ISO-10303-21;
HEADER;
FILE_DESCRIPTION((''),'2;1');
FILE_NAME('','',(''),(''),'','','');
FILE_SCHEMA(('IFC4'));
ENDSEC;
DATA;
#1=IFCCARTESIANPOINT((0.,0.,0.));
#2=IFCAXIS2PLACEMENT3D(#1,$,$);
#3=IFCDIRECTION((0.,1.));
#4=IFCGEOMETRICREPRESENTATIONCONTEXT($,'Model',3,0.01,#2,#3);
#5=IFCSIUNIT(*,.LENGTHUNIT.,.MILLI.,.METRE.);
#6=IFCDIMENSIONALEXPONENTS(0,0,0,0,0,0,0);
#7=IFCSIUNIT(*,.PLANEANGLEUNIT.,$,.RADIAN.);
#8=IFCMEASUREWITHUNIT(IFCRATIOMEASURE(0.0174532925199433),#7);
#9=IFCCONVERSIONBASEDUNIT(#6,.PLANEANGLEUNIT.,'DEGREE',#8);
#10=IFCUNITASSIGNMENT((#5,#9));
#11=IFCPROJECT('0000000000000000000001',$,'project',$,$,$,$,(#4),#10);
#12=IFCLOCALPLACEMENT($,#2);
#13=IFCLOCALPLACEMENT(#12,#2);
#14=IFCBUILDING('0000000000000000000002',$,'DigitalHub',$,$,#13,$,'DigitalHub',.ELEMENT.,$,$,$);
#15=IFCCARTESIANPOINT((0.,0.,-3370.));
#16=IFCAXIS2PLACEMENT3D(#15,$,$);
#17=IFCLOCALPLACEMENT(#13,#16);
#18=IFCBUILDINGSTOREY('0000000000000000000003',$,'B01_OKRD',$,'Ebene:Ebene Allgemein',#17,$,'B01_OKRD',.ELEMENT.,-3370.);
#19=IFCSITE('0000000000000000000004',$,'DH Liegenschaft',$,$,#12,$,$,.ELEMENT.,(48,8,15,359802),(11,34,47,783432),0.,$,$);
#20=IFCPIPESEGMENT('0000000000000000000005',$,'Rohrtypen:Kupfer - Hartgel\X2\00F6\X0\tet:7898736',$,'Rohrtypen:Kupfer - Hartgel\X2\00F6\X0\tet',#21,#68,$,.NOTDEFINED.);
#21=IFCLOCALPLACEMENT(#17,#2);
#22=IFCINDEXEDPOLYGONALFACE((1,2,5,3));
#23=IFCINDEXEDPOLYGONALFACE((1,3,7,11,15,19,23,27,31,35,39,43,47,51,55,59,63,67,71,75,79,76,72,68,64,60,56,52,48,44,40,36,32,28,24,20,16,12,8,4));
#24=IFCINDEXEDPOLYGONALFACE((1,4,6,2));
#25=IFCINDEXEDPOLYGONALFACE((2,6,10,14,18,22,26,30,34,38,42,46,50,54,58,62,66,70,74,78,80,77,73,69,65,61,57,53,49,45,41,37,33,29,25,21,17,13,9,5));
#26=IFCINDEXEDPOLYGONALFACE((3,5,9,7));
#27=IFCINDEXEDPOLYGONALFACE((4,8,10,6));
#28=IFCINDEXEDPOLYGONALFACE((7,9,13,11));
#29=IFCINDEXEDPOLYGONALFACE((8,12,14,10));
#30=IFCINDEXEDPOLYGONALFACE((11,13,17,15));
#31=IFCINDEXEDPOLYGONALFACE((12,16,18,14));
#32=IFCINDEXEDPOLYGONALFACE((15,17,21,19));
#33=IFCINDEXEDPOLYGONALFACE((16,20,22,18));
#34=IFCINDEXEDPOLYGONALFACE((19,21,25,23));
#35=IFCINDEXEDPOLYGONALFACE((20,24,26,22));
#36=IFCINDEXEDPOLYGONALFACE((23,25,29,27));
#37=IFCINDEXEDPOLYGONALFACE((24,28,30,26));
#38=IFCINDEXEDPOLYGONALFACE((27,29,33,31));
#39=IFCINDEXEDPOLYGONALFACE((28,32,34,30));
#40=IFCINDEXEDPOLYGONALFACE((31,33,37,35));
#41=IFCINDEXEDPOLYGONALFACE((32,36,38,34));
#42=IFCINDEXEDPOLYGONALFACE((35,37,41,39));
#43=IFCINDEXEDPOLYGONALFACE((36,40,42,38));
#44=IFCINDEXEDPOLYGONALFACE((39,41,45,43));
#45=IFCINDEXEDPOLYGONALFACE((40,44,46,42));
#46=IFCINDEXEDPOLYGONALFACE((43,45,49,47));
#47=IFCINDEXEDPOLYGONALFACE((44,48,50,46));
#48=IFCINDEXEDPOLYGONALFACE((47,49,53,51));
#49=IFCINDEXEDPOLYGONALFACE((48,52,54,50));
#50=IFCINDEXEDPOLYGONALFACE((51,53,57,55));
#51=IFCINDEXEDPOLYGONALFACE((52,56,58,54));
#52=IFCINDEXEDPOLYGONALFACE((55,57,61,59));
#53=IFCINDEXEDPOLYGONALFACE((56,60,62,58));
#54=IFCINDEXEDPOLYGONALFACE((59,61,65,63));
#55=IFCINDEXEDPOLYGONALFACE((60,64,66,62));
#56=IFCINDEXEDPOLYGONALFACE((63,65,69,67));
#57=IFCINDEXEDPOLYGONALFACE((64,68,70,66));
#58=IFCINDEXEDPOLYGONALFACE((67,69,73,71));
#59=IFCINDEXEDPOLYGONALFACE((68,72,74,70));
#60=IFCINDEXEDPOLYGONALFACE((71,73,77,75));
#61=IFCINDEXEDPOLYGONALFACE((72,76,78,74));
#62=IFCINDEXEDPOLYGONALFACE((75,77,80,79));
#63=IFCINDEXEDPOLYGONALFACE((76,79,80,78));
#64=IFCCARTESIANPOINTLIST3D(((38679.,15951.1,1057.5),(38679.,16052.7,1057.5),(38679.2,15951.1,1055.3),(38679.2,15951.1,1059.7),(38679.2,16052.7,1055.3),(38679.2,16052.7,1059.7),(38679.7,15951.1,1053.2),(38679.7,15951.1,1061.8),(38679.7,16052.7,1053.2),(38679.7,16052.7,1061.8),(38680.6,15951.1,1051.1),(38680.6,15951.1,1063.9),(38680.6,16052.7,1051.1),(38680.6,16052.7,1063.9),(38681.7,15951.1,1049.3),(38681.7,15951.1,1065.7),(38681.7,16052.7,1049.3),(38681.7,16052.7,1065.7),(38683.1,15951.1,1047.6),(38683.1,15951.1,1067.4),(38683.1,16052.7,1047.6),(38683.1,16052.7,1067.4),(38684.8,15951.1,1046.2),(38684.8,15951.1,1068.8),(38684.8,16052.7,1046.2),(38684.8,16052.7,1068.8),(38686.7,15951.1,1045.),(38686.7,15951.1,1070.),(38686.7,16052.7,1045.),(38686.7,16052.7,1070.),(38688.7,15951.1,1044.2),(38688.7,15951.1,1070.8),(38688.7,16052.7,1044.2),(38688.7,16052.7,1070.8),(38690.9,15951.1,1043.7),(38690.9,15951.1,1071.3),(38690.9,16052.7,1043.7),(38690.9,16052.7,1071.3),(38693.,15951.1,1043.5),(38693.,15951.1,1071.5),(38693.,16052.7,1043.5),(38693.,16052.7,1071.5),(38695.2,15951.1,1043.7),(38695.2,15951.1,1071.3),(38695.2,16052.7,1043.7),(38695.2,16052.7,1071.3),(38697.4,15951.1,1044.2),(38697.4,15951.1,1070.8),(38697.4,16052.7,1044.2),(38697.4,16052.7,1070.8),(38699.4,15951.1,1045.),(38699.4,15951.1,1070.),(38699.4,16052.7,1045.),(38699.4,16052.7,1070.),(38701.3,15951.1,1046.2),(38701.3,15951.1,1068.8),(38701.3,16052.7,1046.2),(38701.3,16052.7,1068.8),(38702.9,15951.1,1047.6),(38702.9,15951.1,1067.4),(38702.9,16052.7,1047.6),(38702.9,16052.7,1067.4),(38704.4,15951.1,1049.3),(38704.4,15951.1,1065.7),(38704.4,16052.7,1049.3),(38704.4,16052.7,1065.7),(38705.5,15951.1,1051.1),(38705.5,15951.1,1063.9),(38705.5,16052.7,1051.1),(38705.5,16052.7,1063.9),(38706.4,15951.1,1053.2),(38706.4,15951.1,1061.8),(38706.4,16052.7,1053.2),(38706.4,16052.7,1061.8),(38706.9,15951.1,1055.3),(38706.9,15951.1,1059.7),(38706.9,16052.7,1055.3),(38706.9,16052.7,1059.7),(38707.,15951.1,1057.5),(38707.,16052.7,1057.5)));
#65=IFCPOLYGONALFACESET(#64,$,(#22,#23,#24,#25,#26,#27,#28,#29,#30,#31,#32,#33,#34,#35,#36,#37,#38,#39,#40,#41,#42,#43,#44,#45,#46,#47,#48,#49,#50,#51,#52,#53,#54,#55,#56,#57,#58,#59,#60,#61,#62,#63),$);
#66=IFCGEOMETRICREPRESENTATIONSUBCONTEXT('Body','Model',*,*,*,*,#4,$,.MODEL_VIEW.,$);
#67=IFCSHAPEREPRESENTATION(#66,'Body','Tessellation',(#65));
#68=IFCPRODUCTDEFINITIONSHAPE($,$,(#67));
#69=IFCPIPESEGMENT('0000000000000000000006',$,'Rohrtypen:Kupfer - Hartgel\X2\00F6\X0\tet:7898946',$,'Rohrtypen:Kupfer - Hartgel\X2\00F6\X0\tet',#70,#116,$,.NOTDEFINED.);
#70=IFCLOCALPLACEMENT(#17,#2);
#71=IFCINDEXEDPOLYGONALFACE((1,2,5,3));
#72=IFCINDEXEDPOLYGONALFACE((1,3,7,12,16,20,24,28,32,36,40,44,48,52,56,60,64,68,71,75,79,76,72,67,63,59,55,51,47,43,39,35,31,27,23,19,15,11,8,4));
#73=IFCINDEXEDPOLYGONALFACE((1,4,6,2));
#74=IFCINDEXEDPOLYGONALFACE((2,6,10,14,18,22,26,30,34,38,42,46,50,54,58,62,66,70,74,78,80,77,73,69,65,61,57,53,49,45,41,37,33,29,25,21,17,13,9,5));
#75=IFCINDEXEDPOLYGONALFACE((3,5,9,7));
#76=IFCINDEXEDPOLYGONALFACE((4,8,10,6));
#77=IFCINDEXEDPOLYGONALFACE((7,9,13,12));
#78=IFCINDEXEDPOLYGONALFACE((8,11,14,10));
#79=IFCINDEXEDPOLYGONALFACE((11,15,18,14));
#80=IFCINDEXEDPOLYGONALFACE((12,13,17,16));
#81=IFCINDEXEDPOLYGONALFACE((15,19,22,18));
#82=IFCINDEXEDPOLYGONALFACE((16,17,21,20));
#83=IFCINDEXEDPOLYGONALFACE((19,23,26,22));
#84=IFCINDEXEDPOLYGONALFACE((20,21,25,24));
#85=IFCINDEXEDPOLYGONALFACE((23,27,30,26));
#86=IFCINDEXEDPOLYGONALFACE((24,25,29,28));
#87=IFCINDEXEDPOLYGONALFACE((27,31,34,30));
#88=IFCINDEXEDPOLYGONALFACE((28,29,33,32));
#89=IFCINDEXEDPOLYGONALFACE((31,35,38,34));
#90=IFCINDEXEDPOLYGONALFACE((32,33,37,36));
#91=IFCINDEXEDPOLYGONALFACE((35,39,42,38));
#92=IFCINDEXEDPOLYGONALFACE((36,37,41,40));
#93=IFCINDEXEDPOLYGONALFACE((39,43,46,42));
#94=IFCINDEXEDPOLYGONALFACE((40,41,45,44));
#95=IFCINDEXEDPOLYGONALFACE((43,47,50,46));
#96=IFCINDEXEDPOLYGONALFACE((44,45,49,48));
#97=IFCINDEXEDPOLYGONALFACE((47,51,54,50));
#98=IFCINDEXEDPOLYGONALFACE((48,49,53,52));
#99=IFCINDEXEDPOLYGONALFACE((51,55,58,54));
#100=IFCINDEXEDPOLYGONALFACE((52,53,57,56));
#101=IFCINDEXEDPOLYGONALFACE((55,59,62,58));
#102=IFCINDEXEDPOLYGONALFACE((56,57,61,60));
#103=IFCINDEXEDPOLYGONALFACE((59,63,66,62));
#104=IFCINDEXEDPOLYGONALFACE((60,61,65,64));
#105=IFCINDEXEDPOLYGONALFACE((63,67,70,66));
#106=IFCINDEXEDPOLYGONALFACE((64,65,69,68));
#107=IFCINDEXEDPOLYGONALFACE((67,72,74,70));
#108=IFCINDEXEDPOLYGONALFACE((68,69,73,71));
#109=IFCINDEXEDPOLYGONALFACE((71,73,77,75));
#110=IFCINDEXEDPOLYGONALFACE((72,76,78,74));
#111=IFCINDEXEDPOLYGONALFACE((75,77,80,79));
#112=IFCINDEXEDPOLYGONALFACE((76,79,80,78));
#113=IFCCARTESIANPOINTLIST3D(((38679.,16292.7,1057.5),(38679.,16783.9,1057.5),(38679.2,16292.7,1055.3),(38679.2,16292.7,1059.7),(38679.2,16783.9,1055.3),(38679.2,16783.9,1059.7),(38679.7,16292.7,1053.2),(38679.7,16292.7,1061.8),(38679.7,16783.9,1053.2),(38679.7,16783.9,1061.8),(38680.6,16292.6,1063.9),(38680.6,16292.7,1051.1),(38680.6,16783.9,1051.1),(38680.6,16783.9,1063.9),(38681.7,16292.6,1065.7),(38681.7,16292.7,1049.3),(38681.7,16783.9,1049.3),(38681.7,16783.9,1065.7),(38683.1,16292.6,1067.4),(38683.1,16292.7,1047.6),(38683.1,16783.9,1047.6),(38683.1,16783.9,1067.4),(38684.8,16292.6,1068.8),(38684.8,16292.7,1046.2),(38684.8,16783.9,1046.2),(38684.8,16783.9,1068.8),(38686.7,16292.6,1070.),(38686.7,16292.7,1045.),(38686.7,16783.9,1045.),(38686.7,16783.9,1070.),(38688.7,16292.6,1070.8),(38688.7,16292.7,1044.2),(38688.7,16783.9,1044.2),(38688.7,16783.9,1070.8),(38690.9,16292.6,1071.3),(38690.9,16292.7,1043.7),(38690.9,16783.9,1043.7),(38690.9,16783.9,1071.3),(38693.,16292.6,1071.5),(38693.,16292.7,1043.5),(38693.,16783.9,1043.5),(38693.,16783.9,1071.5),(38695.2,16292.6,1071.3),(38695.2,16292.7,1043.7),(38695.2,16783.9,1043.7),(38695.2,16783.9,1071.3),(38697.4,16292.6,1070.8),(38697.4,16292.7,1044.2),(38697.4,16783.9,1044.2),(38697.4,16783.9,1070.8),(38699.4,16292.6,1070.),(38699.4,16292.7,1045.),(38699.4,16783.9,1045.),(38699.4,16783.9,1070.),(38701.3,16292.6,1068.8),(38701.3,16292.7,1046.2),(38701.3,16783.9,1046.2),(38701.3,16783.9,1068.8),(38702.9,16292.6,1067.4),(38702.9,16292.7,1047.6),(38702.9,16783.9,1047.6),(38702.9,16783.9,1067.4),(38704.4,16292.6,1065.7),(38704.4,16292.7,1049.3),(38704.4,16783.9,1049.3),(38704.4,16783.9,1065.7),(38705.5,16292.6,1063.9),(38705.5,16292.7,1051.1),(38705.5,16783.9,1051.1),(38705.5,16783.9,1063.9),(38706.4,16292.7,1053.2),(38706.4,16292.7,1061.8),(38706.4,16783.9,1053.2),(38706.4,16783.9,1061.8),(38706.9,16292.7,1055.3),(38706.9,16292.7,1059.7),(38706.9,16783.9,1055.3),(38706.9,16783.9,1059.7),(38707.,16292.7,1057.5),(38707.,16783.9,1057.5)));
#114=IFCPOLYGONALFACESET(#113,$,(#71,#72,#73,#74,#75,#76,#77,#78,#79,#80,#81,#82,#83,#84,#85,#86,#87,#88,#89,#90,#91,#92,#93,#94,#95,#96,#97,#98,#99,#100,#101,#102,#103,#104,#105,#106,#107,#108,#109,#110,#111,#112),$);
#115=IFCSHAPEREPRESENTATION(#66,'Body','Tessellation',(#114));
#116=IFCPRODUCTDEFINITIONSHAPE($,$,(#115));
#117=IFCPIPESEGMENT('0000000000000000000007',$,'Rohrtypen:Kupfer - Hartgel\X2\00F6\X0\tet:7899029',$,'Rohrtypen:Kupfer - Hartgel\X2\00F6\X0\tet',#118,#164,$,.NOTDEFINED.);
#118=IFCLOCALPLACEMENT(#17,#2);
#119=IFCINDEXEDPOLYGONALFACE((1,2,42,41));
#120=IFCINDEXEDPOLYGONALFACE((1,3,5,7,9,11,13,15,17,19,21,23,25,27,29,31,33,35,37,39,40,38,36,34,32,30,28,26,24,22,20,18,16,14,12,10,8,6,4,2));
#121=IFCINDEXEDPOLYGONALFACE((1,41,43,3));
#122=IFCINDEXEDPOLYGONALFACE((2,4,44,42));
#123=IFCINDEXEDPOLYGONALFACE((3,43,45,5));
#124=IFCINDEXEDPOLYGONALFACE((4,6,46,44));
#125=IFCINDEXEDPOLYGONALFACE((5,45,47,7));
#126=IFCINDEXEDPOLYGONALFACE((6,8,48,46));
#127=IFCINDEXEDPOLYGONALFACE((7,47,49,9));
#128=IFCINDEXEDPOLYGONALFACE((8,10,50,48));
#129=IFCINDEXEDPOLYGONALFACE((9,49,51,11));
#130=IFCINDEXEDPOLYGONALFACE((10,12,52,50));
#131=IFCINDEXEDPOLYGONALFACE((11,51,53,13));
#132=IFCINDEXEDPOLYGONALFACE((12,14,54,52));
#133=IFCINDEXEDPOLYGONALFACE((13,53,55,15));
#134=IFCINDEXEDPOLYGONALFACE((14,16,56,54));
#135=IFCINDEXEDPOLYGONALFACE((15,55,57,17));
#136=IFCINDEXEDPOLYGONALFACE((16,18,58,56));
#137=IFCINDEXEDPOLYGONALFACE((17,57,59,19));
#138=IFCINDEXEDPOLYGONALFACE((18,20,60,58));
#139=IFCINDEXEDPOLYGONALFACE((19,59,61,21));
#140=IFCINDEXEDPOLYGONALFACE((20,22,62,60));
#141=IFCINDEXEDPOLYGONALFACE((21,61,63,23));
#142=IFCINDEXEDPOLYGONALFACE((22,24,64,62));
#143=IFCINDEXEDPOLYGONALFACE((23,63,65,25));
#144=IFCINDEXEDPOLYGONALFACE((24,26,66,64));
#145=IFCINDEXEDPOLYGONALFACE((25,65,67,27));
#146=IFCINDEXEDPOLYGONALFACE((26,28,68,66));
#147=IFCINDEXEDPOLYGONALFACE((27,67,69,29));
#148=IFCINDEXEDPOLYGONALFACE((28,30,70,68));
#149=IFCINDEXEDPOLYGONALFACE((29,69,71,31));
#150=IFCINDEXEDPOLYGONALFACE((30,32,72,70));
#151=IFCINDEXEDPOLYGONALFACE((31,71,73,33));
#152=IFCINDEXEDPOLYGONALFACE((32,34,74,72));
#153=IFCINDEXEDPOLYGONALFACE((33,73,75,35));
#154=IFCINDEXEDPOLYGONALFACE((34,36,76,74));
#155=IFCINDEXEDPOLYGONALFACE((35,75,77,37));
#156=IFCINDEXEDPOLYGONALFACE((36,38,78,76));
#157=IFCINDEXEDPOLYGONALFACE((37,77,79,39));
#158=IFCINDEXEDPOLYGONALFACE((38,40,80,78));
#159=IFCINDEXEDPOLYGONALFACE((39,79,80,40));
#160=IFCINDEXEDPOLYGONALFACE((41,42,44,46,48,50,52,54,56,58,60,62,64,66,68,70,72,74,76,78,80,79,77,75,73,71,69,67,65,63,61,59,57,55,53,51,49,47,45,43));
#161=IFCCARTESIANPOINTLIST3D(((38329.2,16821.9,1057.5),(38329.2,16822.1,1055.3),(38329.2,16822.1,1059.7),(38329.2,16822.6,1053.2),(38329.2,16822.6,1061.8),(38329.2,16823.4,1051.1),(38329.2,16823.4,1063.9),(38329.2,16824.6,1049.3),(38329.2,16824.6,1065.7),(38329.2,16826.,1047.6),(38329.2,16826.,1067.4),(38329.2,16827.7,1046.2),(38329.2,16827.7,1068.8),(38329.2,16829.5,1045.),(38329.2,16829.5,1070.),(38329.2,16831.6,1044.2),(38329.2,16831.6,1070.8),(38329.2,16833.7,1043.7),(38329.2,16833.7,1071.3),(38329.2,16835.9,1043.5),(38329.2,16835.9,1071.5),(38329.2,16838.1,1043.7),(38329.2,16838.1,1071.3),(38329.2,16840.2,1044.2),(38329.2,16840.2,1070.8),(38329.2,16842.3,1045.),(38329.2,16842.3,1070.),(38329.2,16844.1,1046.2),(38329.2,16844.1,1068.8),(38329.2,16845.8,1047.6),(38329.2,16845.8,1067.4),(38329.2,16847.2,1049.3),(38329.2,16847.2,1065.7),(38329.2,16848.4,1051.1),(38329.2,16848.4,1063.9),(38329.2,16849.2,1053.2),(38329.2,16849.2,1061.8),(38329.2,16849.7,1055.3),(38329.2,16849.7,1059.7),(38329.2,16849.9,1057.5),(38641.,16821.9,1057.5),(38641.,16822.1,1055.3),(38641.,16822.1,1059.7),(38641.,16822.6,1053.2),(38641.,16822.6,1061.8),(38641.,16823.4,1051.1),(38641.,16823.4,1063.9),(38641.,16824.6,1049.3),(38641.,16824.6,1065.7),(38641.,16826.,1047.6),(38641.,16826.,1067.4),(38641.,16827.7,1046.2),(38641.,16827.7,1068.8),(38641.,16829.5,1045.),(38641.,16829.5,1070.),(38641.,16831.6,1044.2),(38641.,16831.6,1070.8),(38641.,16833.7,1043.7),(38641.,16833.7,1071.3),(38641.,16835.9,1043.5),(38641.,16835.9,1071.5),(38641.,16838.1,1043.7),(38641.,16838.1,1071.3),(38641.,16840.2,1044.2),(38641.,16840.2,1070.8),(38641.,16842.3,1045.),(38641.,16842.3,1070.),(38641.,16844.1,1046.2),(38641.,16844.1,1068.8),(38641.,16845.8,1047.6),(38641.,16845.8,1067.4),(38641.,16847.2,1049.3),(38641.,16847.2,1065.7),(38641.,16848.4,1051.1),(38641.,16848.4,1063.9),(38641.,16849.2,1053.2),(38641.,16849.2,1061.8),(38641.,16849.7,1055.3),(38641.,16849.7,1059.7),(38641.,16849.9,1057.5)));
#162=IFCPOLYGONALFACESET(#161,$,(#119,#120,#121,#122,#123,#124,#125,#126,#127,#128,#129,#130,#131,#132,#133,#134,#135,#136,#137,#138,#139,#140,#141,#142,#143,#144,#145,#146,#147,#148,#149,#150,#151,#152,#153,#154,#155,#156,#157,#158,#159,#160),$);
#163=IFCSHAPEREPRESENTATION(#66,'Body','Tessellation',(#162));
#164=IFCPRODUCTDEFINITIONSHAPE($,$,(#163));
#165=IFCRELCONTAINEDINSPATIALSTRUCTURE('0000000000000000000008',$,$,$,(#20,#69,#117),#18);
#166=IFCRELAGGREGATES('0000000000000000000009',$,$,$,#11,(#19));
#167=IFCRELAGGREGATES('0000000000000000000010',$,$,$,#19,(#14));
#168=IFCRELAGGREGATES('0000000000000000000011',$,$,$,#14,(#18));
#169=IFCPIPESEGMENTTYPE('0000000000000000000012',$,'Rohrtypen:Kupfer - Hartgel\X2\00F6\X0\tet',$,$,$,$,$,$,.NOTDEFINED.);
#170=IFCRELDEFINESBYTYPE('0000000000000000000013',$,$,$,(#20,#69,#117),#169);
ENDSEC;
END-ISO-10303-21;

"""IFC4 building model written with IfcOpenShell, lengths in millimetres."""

from ifc_helpers import new_model, entity, si_unit, converted_unit, direction, frame, origin, place, context, subcontext, project, spatial, indexed_curve, outline, extrude, type_object, element, save


model = new_model("IFC4")

# Units and contexts
model_context = context("Model", 3, precision=0.01, world=origin(), true_north=direction((0.0, 1.0)))
body_context = subcontext(model_context, "Body", "Model", "MODEL_VIEW")
ifc_project = project(units=[si_unit("LENGTHUNIT", "METRE", prefix="MILLI"), converted_unit("PLANEANGLEUNIT", "DEGREE", entity("IfcRatioMeasure", 0.0174532925199433), si_unit("PLANEANGLEUNIT", "RADIAN"), dimensions=[0, 0, 0, 0, 0, 0, 0])], contexts=[model_context])

# Site, building, storey
site_placement = place(None, origin())
site = spatial("IfcSite", under=ifc_project, at=site_placement, Name="DH Liegenschaft", CompositionType="ELEMENT", RefLatitude=(48, 8, 15, 359802), RefLongitude=(11, 34, 47, 783432), RefElevation=0.0)
building_placement = place(site_placement, origin())
building = spatial("IfcBuilding", under=site, at=building_placement, Name="DigitalHub", LongName="DigitalHub", CompositionType="ELEMENT")
storey_placement = place(building_placement, frame((0.0, 0.0, -3370.0)))
storey = spatial("IfcBuildingStorey", under=building, at=storey_placement, Name="B01_OKRD", ObjectType="Ebene:Ebene Allgemein", LongName="B01_OKRD", CompositionType="ELEMENT", Elevation=-3370.0)

# Pipe segments
pipe_segment_type = type_object("IfcPipeSegmentType", Name="Rohrtypen:Kupfer - Hartgelötet", PredefinedType="NOTDEFINED")
pipe_segment_1_placement = place(storey_placement, frame((38677.4, 15951.1, 1041.9)))
element("IfcPipeSegment", 1, at=pipe_segment_1_placement, inside=storey, type_object=pipe_segment_type, Name="Rohrtypen:Kupfer - Hartgelötet:7898736", ObjectType="Rohrtypen:Kupfer - Hartgelötet", PredefinedType="NOTDEFINED", context=body_context, shape_type="SweptSolid", body=[
    extrude(outline(indexed_curve([(14.0, 0.0), (13.8, 2.2), (13.3, 4.3), (12.5, 6.4), (11.3, 8.2), (9.9, 9.9), (8.2, 11.3), (6.4, 12.5), (4.3, 13.3), (2.2, 13.8), (0.0, 14.0), (-2.2, 13.8), (-4.3, 13.3), (-6.4, 12.5), (-8.2, 11.3), (-9.9, 9.9), (-11.3, 8.2), (-12.5, 6.4), (-13.3, 4.3), (-13.8, 2.2), (-14.0, 0.0), (-13.8, -2.2), (-13.3, -4.3), (-12.5, -6.4), (-11.3, -8.2), (-9.9, -9.9), (-8.2, -11.3), (-6.4, -12.5), (-4.3, -13.3), (-2.2, -13.8), (0.0, -14.0), (2.2, -13.8), (4.3, -13.3), (6.4, -12.5), (8.2, -11.3), (9.9, -9.9), (11.3, -8.2), (12.5, -6.4), (13.3, -4.3), (13.8, -2.2), (14.0, 0.0)], self_intersect=False)), frame((15.6, 0.0, 15.6), z_axis=(0.0, 1.0, 0.0), x_axis=(1.0, 0.0, 0.0)), (0.0, 0.0, 1.0), 101.6),
])
pipe_segment_2_placement = place(storey_placement, frame((38677.4, 16292.6, 1041.9)))
element("IfcPipeSegment", 2, at=pipe_segment_2_placement, inside=storey, type_object=pipe_segment_type, Name="Rohrtypen:Kupfer - Hartgelötet:7898946", ObjectType="Rohrtypen:Kupfer - Hartgelötet", PredefinedType="NOTDEFINED", context=body_context, shape_type="SweptSolid", body=[
    extrude(outline(indexed_curve([(14.0, 0.0), (13.8, 2.2), (13.3, 4.3), (12.5, 6.4), (11.3, 8.2), (9.9, 9.9), (8.2, 11.3), (6.4, 12.5), (4.3, 13.3), (2.2, 13.8), (0.0, 14.0), (-2.2, 13.8), (-4.3, 13.3), (-6.4, 12.5), (-8.2, 11.3), (-9.9, 9.9), (-11.3, 8.2), (-12.5, 6.4), (-13.3, 4.3), (-13.8, 2.2), (-14.0, 0.0), (-13.8, -2.2), (-13.3, -4.3), (-12.5, -6.4), (-11.3, -8.2), (-9.9, -9.9), (-8.2, -11.3), (-6.4, -12.5), (-4.3, -13.3), (-2.2, -13.8), (0.0, -14.0), (2.2, -13.8), (4.3, -13.3), (6.4, -12.5), (8.2, -11.3), (9.9, -9.9), (11.3, -8.2), (12.5, -6.4), (13.3, -4.3), (13.8, -2.2), (14.0, 0.0)], self_intersect=False)), frame((15.6, 0.0, 15.6), z_axis=(0.0, 1.0, 0.00001), x_axis=(1.0, 0.0, 0.0)), (0.0, 0.0, 1.0), 491.2),
])
pipe_segment_3_placement = place(storey_placement, frame((38329.2, 16820.3, 1041.9)))
element("IfcPipeSegment", 3, at=pipe_segment_3_placement, inside=storey, type_object=pipe_segment_type, Name="Rohrtypen:Kupfer - Hartgelötet:7899029", ObjectType="Rohrtypen:Kupfer - Hartgelötet", PredefinedType="NOTDEFINED", context=body_context, shape_type="SweptSolid", body=[
    extrude(outline(indexed_curve([(14.0, 0.0), (13.8, 2.2), (13.3, 4.3), (12.5, 6.4), (11.3, 8.2), (9.9, 9.9), (8.2, 11.3), (6.4, 12.5), (4.3, 13.3), (2.2, 13.8), (0.0, 14.0), (-2.2, 13.8), (-4.3, 13.3), (-6.4, 12.5), (-8.2, 11.3), (-9.9, 9.9), (-11.3, 8.2), (-12.5, 6.4), (-13.3, 4.3), (-13.8, 2.2), (-14.0, 0.0), (-13.8, -2.2), (-13.3, -4.3), (-12.5, -6.4), (-11.3, -8.2), (-9.9, -9.9), (-8.2, -11.3), (-6.4, -12.5), (-4.3, -13.3), (-2.2, -13.8), (0.0, -14.0), (2.2, -13.8), (4.3, -13.3), (6.4, -12.5), (8.2, -11.3), (9.9, -9.9), (11.3, -8.2), (12.5, -6.4), (13.3, -4.3), (13.8, -2.2), (14.0, 0.0)], self_intersect=False)), frame((0.0, 15.6, 15.6), z_axis=(1.0, 0.0, 0.0), x_axis=(0.0, 1.0, 0.0)), (0.0, 0.0, 1.0), 311.9),
])

save(model, "model.ifc")
